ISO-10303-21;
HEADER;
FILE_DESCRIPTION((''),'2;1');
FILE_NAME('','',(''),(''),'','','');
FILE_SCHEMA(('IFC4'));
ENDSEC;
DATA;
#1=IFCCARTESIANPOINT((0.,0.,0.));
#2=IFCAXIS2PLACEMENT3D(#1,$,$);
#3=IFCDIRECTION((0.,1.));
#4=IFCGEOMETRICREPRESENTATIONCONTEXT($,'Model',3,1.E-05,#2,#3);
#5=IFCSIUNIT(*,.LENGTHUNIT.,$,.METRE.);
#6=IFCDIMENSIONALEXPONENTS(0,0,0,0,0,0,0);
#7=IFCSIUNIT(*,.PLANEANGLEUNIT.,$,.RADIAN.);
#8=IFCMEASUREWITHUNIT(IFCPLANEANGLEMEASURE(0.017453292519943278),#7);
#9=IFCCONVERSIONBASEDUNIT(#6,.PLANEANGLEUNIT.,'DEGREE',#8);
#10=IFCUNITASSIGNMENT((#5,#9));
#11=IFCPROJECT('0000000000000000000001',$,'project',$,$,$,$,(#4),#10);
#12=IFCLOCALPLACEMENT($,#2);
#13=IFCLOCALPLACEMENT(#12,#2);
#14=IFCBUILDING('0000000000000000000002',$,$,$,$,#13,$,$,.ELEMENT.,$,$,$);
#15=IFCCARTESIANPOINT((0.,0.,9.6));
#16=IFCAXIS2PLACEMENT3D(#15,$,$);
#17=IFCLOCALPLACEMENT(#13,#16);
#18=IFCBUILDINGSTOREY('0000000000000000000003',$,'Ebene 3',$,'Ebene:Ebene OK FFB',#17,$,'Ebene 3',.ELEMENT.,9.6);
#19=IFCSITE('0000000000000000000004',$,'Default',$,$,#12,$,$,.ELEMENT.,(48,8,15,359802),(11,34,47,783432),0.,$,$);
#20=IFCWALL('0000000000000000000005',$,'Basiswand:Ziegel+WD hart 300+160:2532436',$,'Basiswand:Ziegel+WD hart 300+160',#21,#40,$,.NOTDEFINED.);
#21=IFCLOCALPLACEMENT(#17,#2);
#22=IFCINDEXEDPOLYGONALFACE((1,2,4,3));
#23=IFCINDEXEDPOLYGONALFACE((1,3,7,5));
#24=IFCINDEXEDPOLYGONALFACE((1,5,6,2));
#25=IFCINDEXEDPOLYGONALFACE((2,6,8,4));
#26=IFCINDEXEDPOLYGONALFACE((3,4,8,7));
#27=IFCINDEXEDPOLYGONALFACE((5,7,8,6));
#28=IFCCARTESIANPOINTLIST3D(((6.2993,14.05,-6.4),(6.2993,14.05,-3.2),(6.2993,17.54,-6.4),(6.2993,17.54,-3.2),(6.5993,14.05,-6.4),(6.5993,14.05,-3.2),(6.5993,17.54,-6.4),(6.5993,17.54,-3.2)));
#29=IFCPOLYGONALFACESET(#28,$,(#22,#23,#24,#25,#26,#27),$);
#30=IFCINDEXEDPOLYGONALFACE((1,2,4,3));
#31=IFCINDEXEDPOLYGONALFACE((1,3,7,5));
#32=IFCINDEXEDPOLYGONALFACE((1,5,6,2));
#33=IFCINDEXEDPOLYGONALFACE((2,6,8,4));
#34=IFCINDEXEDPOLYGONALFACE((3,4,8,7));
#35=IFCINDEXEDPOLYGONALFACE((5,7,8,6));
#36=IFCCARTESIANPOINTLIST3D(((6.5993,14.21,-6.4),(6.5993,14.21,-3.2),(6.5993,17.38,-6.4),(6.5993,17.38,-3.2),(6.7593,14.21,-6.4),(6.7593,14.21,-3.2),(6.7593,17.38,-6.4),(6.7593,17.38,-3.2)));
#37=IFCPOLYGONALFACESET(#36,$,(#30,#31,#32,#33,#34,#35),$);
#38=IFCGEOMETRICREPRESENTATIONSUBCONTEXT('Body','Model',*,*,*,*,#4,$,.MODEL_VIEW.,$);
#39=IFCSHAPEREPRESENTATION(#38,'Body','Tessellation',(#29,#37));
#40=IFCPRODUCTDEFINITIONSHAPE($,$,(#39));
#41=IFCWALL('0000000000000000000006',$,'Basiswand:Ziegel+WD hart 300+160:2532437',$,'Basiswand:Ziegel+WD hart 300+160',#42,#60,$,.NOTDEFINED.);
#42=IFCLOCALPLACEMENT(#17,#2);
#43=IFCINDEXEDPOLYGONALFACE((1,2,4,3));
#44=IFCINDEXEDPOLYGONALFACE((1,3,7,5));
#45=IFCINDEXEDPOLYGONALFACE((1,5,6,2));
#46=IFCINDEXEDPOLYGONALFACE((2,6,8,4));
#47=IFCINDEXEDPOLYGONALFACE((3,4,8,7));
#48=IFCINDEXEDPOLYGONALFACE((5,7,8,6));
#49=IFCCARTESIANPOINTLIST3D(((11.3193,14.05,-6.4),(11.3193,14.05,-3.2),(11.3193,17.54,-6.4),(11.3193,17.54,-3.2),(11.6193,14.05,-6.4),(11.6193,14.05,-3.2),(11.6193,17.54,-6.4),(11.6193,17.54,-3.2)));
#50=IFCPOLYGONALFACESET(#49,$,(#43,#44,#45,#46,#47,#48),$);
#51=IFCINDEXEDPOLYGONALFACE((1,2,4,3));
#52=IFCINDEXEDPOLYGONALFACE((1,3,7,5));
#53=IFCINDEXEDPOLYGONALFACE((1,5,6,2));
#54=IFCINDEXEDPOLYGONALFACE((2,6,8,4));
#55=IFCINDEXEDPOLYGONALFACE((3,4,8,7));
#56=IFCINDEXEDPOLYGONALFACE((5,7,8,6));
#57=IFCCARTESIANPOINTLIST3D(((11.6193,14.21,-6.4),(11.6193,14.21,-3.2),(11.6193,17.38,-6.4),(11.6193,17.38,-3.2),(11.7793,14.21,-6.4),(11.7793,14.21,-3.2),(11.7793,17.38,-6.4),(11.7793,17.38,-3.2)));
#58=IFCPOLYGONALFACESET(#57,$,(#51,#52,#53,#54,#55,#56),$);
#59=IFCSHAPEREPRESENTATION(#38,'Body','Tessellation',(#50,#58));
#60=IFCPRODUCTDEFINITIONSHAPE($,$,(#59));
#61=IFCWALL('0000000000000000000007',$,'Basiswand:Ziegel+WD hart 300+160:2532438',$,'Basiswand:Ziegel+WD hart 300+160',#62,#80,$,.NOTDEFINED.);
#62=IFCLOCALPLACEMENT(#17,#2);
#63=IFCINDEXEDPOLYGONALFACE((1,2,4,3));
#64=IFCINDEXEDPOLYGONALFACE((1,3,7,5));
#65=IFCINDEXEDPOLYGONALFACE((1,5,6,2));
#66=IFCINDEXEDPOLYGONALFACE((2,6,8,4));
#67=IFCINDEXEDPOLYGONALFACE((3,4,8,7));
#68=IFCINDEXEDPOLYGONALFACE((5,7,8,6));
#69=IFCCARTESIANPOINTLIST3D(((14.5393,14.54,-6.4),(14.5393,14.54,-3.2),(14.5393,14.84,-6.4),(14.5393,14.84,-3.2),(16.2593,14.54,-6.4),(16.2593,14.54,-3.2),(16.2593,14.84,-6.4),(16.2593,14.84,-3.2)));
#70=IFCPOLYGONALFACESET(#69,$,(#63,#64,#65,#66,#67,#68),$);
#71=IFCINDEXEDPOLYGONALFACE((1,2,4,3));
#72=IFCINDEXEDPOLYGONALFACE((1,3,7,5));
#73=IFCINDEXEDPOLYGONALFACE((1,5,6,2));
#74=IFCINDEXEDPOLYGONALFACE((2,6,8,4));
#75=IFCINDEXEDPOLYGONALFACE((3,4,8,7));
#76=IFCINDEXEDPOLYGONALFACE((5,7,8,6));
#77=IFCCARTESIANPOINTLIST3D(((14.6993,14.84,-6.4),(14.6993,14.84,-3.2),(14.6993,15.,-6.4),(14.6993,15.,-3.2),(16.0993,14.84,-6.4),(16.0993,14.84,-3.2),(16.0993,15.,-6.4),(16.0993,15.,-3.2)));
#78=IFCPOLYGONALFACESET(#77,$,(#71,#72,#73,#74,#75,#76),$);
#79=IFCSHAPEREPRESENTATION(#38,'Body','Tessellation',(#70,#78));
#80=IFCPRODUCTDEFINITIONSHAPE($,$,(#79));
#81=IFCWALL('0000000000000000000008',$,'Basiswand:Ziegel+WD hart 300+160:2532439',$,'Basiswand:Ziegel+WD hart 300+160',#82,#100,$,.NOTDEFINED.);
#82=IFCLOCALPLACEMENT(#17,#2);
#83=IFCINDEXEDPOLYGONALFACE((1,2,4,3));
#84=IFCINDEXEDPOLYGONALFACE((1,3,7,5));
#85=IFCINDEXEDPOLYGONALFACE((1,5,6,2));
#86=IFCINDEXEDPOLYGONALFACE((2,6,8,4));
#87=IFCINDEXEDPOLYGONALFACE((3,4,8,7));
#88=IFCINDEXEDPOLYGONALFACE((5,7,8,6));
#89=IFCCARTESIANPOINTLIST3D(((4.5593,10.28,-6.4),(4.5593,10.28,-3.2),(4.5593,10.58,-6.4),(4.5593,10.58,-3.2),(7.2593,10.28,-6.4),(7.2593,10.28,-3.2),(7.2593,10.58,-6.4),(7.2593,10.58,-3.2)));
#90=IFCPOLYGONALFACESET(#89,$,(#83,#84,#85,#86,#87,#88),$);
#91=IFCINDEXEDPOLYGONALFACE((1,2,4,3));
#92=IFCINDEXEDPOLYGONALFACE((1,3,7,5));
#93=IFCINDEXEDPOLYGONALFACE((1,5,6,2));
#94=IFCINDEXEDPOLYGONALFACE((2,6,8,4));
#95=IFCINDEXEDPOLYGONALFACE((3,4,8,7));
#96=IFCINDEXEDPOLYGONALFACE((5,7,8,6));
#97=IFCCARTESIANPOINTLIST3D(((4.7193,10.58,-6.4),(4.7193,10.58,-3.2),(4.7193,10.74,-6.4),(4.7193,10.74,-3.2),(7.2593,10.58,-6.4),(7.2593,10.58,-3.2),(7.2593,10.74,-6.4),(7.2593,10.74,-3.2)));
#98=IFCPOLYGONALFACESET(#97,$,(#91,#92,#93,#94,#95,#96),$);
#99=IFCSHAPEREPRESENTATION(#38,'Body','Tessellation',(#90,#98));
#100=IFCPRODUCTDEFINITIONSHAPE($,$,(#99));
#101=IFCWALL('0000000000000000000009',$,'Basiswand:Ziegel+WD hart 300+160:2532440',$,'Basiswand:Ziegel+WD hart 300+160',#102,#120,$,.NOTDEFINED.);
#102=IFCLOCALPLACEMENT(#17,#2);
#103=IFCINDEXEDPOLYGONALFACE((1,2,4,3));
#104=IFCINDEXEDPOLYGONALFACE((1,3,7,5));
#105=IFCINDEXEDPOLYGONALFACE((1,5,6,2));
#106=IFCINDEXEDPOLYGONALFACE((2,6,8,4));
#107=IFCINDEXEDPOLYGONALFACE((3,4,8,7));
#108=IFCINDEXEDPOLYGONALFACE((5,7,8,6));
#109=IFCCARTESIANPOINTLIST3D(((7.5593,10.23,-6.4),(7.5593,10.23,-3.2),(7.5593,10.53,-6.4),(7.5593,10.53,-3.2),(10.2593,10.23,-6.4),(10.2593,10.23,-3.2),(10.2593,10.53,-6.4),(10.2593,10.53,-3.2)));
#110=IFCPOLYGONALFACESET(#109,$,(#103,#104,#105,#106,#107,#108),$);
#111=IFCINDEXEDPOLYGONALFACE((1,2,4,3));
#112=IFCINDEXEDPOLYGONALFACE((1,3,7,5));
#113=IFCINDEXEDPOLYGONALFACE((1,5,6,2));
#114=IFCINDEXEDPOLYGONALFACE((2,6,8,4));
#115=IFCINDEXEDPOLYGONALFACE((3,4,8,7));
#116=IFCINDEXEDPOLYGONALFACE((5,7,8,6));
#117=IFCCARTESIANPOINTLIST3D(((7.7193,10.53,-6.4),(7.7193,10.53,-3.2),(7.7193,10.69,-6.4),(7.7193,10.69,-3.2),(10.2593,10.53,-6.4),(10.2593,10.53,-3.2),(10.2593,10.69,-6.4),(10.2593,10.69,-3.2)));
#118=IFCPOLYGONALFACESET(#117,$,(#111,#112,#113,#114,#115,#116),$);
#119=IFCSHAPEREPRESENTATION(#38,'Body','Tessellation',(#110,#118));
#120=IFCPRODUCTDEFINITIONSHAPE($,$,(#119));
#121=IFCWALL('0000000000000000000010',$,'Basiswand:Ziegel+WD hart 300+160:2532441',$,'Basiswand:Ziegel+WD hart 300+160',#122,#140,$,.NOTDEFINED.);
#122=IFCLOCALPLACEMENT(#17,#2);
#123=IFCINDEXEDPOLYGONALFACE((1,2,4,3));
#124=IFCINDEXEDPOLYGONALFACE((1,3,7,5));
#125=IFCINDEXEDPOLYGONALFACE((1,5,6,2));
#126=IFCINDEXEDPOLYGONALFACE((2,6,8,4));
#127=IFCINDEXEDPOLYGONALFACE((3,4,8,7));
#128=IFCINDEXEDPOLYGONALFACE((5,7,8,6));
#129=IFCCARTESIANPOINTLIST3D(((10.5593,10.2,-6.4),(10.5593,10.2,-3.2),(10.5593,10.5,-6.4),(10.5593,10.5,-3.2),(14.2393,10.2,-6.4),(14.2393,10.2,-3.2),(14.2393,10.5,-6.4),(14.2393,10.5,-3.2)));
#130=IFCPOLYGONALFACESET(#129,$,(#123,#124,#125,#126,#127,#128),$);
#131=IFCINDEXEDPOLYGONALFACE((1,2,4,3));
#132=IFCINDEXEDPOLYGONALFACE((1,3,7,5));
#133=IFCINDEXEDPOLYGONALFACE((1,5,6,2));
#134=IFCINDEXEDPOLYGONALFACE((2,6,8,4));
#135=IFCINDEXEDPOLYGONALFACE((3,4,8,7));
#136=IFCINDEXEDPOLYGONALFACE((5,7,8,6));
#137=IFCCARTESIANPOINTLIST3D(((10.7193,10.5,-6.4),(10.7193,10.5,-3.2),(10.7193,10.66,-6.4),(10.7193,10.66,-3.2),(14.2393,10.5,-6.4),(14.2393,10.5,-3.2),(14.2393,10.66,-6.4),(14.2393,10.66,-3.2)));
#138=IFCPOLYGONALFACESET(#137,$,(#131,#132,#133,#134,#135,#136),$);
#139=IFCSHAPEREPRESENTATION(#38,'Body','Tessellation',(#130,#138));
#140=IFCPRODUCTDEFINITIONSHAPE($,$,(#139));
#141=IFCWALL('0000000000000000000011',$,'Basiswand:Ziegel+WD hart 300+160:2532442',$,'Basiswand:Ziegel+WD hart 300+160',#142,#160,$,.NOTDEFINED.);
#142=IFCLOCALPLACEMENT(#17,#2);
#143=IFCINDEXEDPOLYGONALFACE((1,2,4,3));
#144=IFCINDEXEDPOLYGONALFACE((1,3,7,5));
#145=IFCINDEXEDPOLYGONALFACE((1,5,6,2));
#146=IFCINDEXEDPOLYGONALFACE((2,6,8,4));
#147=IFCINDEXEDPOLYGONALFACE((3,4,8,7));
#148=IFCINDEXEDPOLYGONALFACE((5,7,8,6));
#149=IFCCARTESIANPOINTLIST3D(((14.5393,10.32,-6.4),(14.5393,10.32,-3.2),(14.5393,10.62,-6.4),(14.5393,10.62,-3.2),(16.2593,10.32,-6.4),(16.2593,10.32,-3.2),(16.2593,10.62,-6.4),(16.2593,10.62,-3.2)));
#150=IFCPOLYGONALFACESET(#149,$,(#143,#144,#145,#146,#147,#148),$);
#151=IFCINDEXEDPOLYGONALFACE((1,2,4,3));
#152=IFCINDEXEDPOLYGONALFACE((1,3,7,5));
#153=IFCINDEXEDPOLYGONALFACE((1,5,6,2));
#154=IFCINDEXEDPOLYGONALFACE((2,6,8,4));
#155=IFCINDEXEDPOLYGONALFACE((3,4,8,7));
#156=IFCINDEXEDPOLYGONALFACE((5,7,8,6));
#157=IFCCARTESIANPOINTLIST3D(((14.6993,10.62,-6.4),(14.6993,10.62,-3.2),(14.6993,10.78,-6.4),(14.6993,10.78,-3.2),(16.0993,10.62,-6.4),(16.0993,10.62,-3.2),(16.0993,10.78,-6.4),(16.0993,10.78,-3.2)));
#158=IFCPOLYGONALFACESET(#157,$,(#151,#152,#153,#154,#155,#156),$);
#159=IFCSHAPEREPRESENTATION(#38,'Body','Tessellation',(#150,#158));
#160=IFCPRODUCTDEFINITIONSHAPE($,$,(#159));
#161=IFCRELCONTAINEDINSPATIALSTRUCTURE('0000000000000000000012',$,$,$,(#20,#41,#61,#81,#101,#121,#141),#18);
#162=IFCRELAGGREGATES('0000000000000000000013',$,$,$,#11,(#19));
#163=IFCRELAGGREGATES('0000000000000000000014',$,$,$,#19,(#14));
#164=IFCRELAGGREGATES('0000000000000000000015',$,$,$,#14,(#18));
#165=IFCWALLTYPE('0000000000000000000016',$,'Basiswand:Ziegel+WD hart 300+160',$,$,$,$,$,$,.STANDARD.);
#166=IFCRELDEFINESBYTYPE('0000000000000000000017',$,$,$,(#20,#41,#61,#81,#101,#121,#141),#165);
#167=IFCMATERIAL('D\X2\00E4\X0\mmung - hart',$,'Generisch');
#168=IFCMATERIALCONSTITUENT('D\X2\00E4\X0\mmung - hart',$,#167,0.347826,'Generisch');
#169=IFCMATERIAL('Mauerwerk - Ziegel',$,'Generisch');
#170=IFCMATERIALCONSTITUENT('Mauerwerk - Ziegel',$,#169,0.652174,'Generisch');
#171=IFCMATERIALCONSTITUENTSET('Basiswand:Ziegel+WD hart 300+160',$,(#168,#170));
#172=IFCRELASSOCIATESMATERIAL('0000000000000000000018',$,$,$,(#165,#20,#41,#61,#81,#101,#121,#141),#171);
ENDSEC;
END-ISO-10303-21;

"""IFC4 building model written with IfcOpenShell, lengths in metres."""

from ifc_helpers import new_model, entity, si_unit, converted_unit, direction, frame, origin, place, context, subcontext, project, spatial, indexed_curve, outline, extrude, material, constituent, constituent_set, type_object, element, save


model = new_model("IFC4")

# Units and contexts
model_context = context("Model", 3, precision=1e-05, world=origin(), true_north=direction((0.0, 1.0)))
body_context = subcontext(model_context, "Body", "Model", "MODEL_VIEW")
ifc_project = project(units=[si_unit("LENGTHUNIT", "METRE"), converted_unit("PLANEANGLEUNIT", "DEGREE", entity("IfcPlaneAngleMeasure", 0.017453292519943278), si_unit("PLANEANGLEUNIT", "RADIAN"), dimensions=[0, 0, 0, 0, 0, 0, 0])], contexts=[model_context])

# Site, building, storey
site_placement = place(None, origin())
site = spatial("IfcSite", under=ifc_project, at=site_placement, Name="Default", CompositionType="ELEMENT", RefLatitude=(48, 8, 15, 359802), RefLongitude=(11, 34, 47, 783432), RefElevation=0.0)
building_placement = place(site_placement, origin())
building = spatial("IfcBuilding", under=site, at=building_placement, CompositionType="ELEMENT")
storey_placement = place(building_placement, frame((0.0, 0.0, 9.6)))
storey = spatial("IfcBuildingStorey", under=building, at=storey_placement, Name="Ebene 3", ObjectType="Ebene:Ebene OK FFB", LongName="Ebene 3", CompositionType="ELEMENT", Elevation=9.6)

# Walls
ifc_material_1 = material(Name="Dämmung - hart", Category="Generisch")
ifc_constituent_1 = constituent(ifc_material_1, Name="Dämmung - hart", Category="Generisch", fraction=0.347826)
ifc_material_2 = material(Name="Mauerwerk - Ziegel", Category="Generisch")
ifc_constituent_2 = constituent(ifc_material_2, Name="Mauerwerk - Ziegel", Category="Generisch", fraction=0.652174)
ifc_constituent_set = constituent_set(constituents=[ifc_constituent_1, ifc_constituent_2], Name="Basiswand:Ziegel+WD hart 300+160")
wall_type = type_object("IfcWallType", Name="Basiswand:Ziegel+WD hart 300+160", PredefinedType="STANDARD", material=ifc_constituent_set)
wall_1_placement = place(storey_placement, frame((6.5293, 17.38, -6.4), z_axis=(0.0, 0.0, 1.0), x_axis=(0.0, -1.0, 0.0)))
element("IfcWall", 1, at=wall_1_placement, inside=storey, type_object=wall_type, material=ifc_constituent_set, Name="Basiswand:Ziegel+WD hart 300+160:2532436", ObjectType="Basiswand:Ziegel+WD hart 300+160", PredefinedType="NOTDEFINED", context=body_context, shape_type="SweptSolid", body=[
    extrude(outline(indexed_curve([(-0.15, -1.745), (0.15, -1.745), (0.15, 1.745), (-0.15, 1.745), (-0.15, -1.745)], self_intersect=False)), frame((1.585, -0.08, 0.0), z_axis=(0.0, 0.0, 1.0), x_axis=(0.0, 1.0, 0.0)), (0.0, 0.0, 1.0), 3.2),
    extrude(outline(indexed_curve([(-0.08, -1.585), (0.08, -1.585), (0.08, 1.585), (-0.08, 1.585), (-0.08, -1.585)], self_intersect=False)), frame((1.585, 0.15, 0.0), z_axis=(0.0, 0.0, 1.0), x_axis=(0.0, -1.0, 0.0)), (0.0, 0.0, 1.0), 3.2),
])
wall_2_placement = place(storey_placement, frame((11.5493, 17.38, -6.4), z_axis=(0.0, 0.0, 1.0), x_axis=(0.0, -1.0, 0.0)))
element("IfcWall", 2, at=wall_2_placement, inside=storey, type_object=wall_type, material=ifc_constituent_set, Name="Basiswand:Ziegel+WD hart 300+160:2532437", ObjectType="Basiswand:Ziegel+WD hart 300+160", PredefinedType="NOTDEFINED", context=body_context, shape_type="SweptSolid", body=[
    extrude(outline(indexed_curve([(-0.15, -1.745), (0.15, -1.745), (0.15, 1.745), (-0.15, 1.745), (-0.15, -1.745)], self_intersect=False)), frame((1.585, -0.08, 0.0), z_axis=(0.0, 0.0, 1.0), x_axis=(0.0, 1.0, 0.0)), (0.0, 0.0, 1.0), 3.2),
    extrude(outline(indexed_curve([(-0.08, -1.585), (0.08, -1.585), (0.08, 1.585), (-0.08, 1.585), (-0.08, -1.585)], self_intersect=False)), frame((1.585, 0.15, 0.0), z_axis=(0.0, 0.0, 1.0), x_axis=(0.0, -1.0, 0.0)), (0.0, 0.0, 1.0), 3.2),
])
wall_3_placement = place(storey_placement, frame((14.6993, 14.77, -6.4)))
element("IfcWall", 3, at=wall_3_placement, inside=storey, type_object=wall_type, material=ifc_constituent_set, Name="Basiswand:Ziegel+WD hart 300+160:2532438", ObjectType="Basiswand:Ziegel+WD hart 300+160", PredefinedType="NOTDEFINED", context=body_context, shape_type="SweptSolid", body=[
    extrude(outline(indexed_curve([(-0.15, -0.86), (0.15, -0.86), (0.15, 0.86), (-0.15, 0.86), (-0.15, -0.86)], self_intersect=False)), frame((0.7, -0.08, 0.0), z_axis=(0.0, 0.0, 1.0), x_axis=(0.0, 1.0, 0.0)), (0.0, 0.0, 1.0), 3.2),
    extrude(outline(indexed_curve([(-0.08, -0.7), (0.08, -0.7), (0.08, 0.7), (-0.08, 0.7), (-0.08, -0.7)], self_intersect=False)), frame((0.7, 0.15, 0.0), z_axis=(0.0, 0.0, 1.0), x_axis=(0.0, -1.0, 0.0)), (0.0, 0.0, 1.0), 3.2),
])
wall_4_placement = place(storey_placement, frame((4.7193, 10.51, -6.4)))
element("IfcWall", 4, at=wall_4_placement, inside=storey, type_object=wall_type, material=ifc_constituent_set, Name="Basiswand:Ziegel+WD hart 300+160:2532439", ObjectType="Basiswand:Ziegel+WD hart 300+160", PredefinedType="NOTDEFINED", context=body_context, shape_type="SweptSolid", body=[
    extrude(outline(indexed_curve([(-0.15, -1.35), (0.15, -1.35), (0.15, 1.35), (-0.15, 1.35), (-0.15, -1.35)], self_intersect=False)), frame((1.19, -0.08, 0.0), z_axis=(0.0, 0.0, 1.0), x_axis=(0.0, 1.0, 0.0)), (0.0, 0.0, 1.0), 3.2),
    extrude(outline(indexed_curve([(-0.08, -1.27), (0.08, -1.27), (0.08, 1.27), (-0.08, 1.27), (-0.08, -1.27)], self_intersect=False)), frame((1.27, 0.15, 0.0), z_axis=(0.0, 0.0, 1.0), x_axis=(0.0, -1.0, 0.0)), (0.0, 0.0, 1.0), 3.2),
])
wall_5_placement = place(storey_placement, frame((7.7193, 10.46, -6.4)))
element("IfcWall", 5, at=wall_5_placement, inside=storey, type_object=wall_type, material=ifc_constituent_set, Name="Basiswand:Ziegel+WD hart 300+160:2532440", ObjectType="Basiswand:Ziegel+WD hart 300+160", PredefinedType="NOTDEFINED", context=body_context, shape_type="SweptSolid", body=[
    extrude(outline(indexed_curve([(-0.15, -1.35), (0.15, -1.35), (0.15, 1.35), (-0.15, 1.35), (-0.15, -1.35)], self_intersect=False)), frame((1.19, -0.08, 0.0), z_axis=(0.0, 0.0, 1.0), x_axis=(0.0, 1.0, 0.0)), (0.0, 0.0, 1.0), 3.2),
    extrude(outline(indexed_curve([(-0.08, -1.27), (0.08, -1.27), (0.08, 1.27), (-0.08, 1.27), (-0.08, -1.27)], self_intersect=False)), frame((1.27, 0.15, 0.0), z_axis=(0.0, 0.0, 1.0), x_axis=(0.0, -1.0, 0.0)), (0.0, 0.0, 1.0), 3.2),
])
wall_6_placement = place(storey_placement, frame((10.7193, 10.43, -6.4)))
element("IfcWall", 6, at=wall_6_placement, inside=storey, type_object=wall_type, material=ifc_constituent_set, Name="Basiswand:Ziegel+WD hart 300+160:2532441", ObjectType="Basiswand:Ziegel+WD hart 300+160", PredefinedType="NOTDEFINED", context=body_context, shape_type="SweptSolid", body=[
    extrude(outline(indexed_curve([(-0.15, -1.84), (0.15, -1.84), (0.15, 1.84), (-0.15, 1.84), (-0.15, -1.84)], self_intersect=False)), frame((1.68, -0.08, 0.0), z_axis=(0.0, 0.0, 1.0), x_axis=(0.0, 1.0, 0.0)), (0.0, 0.0, 1.0), 3.2),
    extrude(outline(indexed_curve([(-0.08, -1.76), (0.08, -1.76), (0.08, 1.76), (-0.08, 1.76), (-0.08, -1.76)], self_intersect=False)), frame((1.76, 0.15, 0.0), z_axis=(0.0, 0.0, 1.0), x_axis=(0.0, -1.0, 0.0)), (0.0, 0.0, 1.0), 3.2),
])
wall_7_placement = place(storey_placement, frame((14.6993, 10.55, -6.4)))
element("IfcWall", 7, at=wall_7_placement, inside=storey, type_object=wall_type, material=ifc_constituent_set, Name="Basiswand:Ziegel+WD hart 300+160:2532442", ObjectType="Basiswand:Ziegel+WD hart 300+160", PredefinedType="NOTDEFINED", context=body_context, shape_type="SweptSolid", body=[
    extrude(outline(indexed_curve([(-0.15, -0.86), (0.15, -0.86), (0.15, 0.86), (-0.15, 0.86), (-0.15, -0.86)], self_intersect=False)), frame((0.7, -0.08, 0.0), z_axis=(0.0, 0.0, 1.0), x_axis=(0.0, 1.0, 0.0)), (0.0, 0.0, 1.0), 3.2),
    extrude(outline(indexed_curve([(-0.08, -0.7), (0.08, -0.7), (0.08, 0.7), (-0.08, 0.7), (-0.08, -0.7)], self_intersect=False)), frame((0.7, 0.15, 0.0), z_axis=(0.0, 0.0, 1.0), x_axis=(0.0, -1.0, 0.0)), (0.0, 0.0, 1.0), 3.2),
])

save(model, "model.ifc")
